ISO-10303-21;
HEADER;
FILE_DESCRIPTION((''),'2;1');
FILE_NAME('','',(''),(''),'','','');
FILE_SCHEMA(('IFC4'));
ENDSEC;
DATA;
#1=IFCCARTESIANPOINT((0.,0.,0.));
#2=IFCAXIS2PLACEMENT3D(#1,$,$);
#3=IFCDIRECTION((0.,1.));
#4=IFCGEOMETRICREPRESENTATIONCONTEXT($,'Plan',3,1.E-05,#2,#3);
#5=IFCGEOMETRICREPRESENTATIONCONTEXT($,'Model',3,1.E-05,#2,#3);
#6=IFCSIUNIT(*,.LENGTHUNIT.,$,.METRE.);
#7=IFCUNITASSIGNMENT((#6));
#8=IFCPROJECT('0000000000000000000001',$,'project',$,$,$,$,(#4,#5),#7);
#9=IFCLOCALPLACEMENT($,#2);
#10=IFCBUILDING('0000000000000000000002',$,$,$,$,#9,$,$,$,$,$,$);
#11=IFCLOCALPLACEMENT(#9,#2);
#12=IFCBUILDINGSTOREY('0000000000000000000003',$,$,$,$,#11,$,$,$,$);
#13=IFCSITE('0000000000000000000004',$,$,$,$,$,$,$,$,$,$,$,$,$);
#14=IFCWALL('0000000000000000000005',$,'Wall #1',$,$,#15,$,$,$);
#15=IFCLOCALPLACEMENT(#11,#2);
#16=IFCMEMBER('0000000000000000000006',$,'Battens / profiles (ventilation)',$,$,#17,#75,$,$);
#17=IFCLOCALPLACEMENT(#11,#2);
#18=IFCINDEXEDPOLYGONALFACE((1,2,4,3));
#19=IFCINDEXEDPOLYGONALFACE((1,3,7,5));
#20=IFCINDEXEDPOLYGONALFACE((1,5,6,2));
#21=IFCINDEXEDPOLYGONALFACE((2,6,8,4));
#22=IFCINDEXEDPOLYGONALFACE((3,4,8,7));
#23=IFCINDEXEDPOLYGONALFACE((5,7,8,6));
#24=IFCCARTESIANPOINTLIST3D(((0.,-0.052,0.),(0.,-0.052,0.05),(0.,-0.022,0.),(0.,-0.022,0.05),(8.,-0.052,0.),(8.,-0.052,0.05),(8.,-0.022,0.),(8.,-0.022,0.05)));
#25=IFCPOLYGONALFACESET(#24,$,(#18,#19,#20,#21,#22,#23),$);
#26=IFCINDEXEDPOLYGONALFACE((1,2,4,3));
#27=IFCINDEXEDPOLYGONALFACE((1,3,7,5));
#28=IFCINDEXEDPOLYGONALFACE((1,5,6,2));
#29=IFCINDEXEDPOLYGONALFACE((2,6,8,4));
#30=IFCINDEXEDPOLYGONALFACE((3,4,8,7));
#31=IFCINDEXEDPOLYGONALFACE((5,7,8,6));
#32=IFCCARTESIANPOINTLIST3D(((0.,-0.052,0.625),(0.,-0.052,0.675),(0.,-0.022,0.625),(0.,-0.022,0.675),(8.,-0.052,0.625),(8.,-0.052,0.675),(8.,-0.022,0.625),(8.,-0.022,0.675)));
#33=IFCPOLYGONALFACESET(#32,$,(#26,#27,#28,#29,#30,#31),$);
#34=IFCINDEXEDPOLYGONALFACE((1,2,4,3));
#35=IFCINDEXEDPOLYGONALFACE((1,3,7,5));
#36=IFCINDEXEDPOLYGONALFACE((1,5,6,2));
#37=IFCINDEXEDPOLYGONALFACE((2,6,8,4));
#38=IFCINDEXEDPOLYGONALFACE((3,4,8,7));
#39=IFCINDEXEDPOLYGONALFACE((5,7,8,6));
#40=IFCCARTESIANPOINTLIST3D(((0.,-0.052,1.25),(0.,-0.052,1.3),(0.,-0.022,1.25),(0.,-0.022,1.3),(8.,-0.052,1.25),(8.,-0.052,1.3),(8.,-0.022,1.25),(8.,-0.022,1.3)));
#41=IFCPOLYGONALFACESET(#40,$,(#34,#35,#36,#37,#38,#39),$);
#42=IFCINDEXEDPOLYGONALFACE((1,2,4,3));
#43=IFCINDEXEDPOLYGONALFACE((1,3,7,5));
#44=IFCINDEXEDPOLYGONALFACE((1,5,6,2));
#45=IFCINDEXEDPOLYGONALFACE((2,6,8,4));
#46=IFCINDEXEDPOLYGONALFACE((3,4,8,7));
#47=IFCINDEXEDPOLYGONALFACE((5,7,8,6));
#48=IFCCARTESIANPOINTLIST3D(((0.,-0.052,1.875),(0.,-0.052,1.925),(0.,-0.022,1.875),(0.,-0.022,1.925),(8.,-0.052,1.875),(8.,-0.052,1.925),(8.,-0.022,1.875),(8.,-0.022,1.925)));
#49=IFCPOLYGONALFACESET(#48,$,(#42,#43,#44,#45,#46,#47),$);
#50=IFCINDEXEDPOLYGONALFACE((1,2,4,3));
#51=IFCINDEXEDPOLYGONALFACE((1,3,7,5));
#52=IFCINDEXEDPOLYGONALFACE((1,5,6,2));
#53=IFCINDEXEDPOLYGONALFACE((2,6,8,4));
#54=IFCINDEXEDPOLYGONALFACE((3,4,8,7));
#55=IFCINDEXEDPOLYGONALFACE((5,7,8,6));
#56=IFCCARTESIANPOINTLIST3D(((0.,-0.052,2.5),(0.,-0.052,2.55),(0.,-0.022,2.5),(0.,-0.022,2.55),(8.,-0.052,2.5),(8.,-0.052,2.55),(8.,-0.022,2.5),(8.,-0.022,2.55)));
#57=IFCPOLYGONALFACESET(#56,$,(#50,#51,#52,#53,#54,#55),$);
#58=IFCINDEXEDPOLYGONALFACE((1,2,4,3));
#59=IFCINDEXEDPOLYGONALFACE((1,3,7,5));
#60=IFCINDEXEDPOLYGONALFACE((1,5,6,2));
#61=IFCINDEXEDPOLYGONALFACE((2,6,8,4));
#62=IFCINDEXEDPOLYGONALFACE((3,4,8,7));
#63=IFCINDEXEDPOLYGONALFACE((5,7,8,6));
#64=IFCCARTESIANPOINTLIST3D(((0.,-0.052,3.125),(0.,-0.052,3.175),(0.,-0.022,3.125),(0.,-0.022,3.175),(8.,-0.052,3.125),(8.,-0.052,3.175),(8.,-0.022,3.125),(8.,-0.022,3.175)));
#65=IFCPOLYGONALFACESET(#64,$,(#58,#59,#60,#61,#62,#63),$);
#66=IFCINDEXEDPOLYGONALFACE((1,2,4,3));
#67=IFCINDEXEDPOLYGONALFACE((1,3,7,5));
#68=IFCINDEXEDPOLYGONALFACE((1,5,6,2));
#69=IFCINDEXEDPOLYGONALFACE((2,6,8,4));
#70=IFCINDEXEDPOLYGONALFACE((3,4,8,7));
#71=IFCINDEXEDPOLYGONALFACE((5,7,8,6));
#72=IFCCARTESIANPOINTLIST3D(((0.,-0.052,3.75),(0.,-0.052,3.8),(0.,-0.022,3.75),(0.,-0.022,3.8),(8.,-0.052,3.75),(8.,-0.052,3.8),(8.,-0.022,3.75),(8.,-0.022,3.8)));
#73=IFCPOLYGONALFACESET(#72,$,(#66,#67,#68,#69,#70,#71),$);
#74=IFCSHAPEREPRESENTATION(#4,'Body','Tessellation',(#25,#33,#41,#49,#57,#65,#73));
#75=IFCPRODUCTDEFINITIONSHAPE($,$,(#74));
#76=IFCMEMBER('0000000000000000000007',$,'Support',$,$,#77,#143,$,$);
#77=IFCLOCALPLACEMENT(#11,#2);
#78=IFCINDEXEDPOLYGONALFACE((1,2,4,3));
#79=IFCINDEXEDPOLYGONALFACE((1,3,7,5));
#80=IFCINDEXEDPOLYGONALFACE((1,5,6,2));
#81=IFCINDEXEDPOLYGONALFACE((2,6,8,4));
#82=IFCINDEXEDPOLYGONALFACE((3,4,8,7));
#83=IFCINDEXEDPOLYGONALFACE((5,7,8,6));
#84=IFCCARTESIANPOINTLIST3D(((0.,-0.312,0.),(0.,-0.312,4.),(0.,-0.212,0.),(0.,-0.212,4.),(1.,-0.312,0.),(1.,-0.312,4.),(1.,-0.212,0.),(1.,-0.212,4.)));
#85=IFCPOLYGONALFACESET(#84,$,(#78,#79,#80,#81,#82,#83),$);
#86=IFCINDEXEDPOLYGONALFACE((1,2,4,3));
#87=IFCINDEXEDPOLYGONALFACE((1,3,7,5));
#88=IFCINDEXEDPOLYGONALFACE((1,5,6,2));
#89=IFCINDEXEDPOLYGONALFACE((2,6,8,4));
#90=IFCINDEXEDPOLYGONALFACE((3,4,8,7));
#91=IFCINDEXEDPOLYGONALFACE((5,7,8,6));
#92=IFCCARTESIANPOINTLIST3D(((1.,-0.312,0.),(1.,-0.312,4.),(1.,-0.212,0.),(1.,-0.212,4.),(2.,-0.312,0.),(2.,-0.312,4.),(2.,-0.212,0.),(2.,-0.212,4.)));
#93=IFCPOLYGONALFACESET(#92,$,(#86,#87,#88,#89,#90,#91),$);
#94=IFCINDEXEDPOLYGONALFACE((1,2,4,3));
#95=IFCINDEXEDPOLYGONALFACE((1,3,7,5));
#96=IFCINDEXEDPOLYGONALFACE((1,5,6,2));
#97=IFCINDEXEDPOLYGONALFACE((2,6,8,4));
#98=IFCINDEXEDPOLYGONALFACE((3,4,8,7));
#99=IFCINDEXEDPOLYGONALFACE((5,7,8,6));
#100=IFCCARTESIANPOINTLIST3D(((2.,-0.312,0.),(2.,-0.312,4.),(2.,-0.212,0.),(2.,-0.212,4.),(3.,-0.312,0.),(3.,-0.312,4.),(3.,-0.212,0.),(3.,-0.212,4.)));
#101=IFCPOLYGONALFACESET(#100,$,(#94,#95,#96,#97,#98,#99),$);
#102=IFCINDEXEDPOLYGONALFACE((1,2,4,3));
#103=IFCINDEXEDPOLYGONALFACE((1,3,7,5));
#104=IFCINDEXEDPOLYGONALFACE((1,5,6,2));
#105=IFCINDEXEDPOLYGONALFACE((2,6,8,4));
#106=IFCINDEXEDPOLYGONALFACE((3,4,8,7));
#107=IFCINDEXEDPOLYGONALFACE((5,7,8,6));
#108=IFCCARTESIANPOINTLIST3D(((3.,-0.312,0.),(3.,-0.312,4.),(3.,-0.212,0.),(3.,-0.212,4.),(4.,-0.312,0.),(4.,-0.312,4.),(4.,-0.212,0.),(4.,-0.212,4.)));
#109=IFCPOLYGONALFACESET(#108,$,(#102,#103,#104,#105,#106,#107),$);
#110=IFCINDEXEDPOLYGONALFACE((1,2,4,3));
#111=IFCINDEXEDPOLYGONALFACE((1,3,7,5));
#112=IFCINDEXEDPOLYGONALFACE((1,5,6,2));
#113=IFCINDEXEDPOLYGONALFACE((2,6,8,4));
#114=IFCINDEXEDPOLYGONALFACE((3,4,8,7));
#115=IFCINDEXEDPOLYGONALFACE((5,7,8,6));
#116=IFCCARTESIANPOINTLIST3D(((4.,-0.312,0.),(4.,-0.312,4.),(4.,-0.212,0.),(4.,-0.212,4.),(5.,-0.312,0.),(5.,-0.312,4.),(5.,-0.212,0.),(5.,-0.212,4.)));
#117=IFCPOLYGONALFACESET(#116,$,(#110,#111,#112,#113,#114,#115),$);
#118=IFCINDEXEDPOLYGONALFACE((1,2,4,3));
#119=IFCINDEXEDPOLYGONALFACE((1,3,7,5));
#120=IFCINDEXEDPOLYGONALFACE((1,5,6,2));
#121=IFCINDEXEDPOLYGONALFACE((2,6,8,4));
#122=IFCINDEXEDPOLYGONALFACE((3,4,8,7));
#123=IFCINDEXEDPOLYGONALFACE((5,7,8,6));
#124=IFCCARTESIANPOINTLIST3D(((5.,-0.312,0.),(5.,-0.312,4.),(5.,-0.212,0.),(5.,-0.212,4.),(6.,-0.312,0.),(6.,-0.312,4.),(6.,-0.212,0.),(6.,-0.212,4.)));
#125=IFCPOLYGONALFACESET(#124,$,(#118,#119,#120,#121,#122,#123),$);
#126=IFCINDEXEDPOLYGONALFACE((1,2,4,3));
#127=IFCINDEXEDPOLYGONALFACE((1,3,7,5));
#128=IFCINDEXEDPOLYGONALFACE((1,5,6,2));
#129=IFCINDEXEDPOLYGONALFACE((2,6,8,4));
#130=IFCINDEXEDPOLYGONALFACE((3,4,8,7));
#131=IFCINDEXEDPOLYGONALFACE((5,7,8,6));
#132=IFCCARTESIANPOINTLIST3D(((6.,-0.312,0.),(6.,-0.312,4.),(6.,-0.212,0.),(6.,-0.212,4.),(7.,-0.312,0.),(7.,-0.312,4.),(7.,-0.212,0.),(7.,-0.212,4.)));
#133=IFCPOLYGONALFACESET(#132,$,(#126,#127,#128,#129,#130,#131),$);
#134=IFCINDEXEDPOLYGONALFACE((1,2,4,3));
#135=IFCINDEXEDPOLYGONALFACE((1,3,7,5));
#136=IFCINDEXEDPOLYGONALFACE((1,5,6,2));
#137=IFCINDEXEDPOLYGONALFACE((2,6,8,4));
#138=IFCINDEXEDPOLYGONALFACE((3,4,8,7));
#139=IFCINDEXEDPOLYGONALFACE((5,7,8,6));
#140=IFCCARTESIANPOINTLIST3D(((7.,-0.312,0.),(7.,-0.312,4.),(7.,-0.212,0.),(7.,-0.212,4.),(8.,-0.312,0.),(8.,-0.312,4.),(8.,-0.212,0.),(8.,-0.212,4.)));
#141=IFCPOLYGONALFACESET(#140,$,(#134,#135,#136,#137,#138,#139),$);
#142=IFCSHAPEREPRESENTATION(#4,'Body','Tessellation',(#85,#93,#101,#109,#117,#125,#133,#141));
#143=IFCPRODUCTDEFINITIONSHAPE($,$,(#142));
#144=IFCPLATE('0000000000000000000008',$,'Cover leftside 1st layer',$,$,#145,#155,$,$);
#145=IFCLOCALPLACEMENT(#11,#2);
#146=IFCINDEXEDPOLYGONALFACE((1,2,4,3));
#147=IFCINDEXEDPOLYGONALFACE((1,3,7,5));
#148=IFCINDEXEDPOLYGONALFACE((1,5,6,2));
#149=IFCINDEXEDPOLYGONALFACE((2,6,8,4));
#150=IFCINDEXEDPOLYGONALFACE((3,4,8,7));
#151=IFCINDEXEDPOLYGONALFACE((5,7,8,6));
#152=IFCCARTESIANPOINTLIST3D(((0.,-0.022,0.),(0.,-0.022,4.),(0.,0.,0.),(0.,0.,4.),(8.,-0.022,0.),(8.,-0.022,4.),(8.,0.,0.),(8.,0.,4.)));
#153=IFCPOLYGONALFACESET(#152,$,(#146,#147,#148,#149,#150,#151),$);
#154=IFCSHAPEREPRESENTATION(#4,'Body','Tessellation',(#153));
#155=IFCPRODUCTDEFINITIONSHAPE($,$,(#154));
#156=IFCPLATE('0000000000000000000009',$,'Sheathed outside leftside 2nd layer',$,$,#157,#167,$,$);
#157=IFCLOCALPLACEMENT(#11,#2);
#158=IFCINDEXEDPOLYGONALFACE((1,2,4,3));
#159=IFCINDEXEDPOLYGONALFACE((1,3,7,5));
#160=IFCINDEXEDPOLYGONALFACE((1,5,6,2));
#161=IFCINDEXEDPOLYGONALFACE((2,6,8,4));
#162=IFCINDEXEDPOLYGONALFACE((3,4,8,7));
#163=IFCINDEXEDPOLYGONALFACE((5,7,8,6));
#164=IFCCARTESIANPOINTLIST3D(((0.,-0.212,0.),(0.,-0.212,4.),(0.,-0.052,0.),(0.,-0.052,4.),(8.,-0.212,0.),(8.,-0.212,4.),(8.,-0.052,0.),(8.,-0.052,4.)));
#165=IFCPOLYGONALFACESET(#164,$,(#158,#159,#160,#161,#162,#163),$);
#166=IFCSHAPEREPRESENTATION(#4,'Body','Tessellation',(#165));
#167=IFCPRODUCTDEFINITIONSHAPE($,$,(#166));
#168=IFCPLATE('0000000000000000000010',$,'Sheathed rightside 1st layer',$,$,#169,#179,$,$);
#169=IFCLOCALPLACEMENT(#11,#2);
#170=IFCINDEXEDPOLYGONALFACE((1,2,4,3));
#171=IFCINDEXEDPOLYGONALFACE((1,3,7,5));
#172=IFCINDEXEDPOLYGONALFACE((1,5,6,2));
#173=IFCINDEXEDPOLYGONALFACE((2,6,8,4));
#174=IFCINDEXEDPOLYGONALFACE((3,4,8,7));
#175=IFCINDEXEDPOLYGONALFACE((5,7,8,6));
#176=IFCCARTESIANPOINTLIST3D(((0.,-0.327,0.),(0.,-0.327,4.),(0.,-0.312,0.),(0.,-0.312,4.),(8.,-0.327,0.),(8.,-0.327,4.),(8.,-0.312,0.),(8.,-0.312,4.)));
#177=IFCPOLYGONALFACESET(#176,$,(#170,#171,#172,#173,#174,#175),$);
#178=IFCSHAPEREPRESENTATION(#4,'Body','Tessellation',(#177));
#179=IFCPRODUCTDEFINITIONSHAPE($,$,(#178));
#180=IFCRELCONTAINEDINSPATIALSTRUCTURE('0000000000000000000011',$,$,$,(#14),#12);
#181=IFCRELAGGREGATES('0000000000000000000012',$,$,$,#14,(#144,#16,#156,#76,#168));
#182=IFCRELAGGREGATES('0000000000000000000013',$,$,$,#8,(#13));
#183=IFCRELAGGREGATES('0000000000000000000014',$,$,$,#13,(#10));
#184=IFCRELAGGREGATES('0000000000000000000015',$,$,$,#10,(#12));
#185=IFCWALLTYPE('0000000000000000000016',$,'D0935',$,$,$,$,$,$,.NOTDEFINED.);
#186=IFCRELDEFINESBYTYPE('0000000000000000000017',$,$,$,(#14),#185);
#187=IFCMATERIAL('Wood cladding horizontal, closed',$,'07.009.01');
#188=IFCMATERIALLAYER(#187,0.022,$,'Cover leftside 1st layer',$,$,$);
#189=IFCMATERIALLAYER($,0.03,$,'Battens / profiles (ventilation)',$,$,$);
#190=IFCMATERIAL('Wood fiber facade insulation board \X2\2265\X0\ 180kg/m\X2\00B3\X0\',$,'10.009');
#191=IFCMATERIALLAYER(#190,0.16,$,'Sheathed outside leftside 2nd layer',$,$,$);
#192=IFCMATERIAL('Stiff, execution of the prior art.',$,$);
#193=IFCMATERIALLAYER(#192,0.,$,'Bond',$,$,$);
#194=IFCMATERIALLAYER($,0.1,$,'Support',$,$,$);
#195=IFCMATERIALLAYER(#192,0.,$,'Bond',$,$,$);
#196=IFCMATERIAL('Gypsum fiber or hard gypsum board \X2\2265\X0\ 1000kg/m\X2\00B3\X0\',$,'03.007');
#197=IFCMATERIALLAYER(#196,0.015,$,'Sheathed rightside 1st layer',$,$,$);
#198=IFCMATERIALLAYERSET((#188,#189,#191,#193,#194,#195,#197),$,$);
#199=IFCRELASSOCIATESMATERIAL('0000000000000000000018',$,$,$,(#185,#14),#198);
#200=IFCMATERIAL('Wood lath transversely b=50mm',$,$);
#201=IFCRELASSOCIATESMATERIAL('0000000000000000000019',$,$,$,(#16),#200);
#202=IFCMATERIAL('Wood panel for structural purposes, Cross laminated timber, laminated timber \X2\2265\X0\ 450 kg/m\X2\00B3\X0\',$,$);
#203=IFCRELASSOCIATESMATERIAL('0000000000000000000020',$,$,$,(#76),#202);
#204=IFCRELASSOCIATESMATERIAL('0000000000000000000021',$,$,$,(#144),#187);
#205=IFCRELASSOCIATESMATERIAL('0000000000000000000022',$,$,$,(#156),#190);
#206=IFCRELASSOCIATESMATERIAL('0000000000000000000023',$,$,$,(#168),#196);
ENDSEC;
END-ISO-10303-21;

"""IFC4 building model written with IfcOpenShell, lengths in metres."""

from ifc_helpers import new_model, si_unit, direction, frame, frame_2d, origin, origin_with_axes, place, context, project, spatial, rectangle, extrude, material, layer, layer_set, type_object, element, aggregate, save


model = new_model("IFC4")

# Units and contexts
plan_context = context("Plan", 3, precision=1e-05, world=origin(), true_north=direction((0.0, 1.0)))
model_context = context("Model", 3, precision=1e-05, world=origin(), true_north=direction((0.0, 1.0)))
ifc_project = project(units=[si_unit("LENGTHUNIT", "METRE")], contexts=[plan_context, model_context])

# Site, building, storey
site = spatial("IfcSite", under=ifc_project)
building_placement = place(None, origin())
building = spatial("IfcBuilding", under=site, at=building_placement)
storey_placement = place(building_placement, origin())
storey = spatial("IfcBuildingStorey", under=building, at=storey_placement)

# Wall, members, plates
ifc_material_1 = material(Name="Wood cladding horizontal, closed", Category="07.009.01")
ifc_layer_1 = layer(ifc_material_1, 0.022, Name="Cover leftside 1st layer")
ifc_layer_2 = layer(None, 0.03, Name="Battens / profiles (ventilation)")
ifc_material_2 = material(Name="Wood fiber facade insulation board ≥ 180kg/m³", Category="10.009")
ifc_layer_3 = layer(ifc_material_2, 0.16, Name="Sheathed outside leftside 2nd layer")
ifc_material_3 = material(Name="Stiff, execution of the prior art.")
ifc_layer_4 = layer(ifc_material_3, 0.0, Name="Bond")
ifc_layer_5 = layer(None, 0.1, Name="Support")
ifc_layer_6 = layer(ifc_material_3, 0.0, Name="Bond")
ifc_material_4 = material(Name="Gypsum fiber or hard gypsum board ≥ 1000kg/m³", Category="03.007")
ifc_layer_7 = layer(ifc_material_4, 0.015, Name="Sheathed rightside 1st layer")
ifc_layer_set = layer_set([ifc_layer_1, ifc_layer_2, ifc_layer_3, ifc_layer_4, ifc_layer_5, ifc_layer_6, ifc_layer_7])
wall_type = type_object("IfcWallType", Name="D0935", PredefinedType="NOTDEFINED", material=ifc_layer_set)
wall_placement = place(None, frame((0.0, 0.0, 0.0), z_axis=(0.0, -1.0, 0.0), x_axis=(1.0, 0.0, 0.0)))
wall = element("IfcWall", 1, at=wall_placement, inside=storey, type_object=wall_type, material=ifc_layer_set, Name="Wall #1")
ifc_material_5 = material(Name="Wood lath transversely b=50mm")
member_1_placement = place(wall_placement, origin())
member_1 = element("IfcMember", 2, at=member_1_placement, material=ifc_material_5, Name="Battens / profiles (ventilation)", context=plan_context, shape_type="SweptSolid", body=[
    extrude(rectangle(XDim=0.05, YDim=0.03, at=frame_2d((0.025, 0.015), x_axis=(1.0, 0.0))), frame((0.0, 0.0, 0.022), z_axis=(1.0, 0.0, 0.0), x_axis=(0.0, 1.0, 0.0)), (0.0, 0.0, 1.0), 8.0),
    extrude(rectangle(XDim=0.05, YDim=0.03, at=frame_2d((0.025, 0.015), x_axis=(1.0, 0.0))), frame((0.0, 0.625, 0.022), z_axis=(1.0, 0.0, 0.0), x_axis=(0.0, 1.0, 0.0)), (0.0, 0.0, 1.0), 8.0),
    extrude(rectangle(XDim=0.05, YDim=0.03, at=frame_2d((0.025, 0.015), x_axis=(1.0, 0.0))), frame((0.0, 1.25, 0.022), z_axis=(1.0, 0.0, 0.0), x_axis=(0.0, 1.0, 0.0)), (0.0, 0.0, 1.0), 8.0),
    extrude(rectangle(XDim=0.05, YDim=0.03, at=frame_2d((0.025, 0.015), x_axis=(1.0, 0.0))), frame((0.0, 1.875, 0.022), z_axis=(1.0, 0.0, 0.0), x_axis=(0.0, 1.0, 0.0)), (0.0, 0.0, 1.0), 8.0),
    extrude(rectangle(XDim=0.05, YDim=0.03, at=frame_2d((0.025, 0.015), x_axis=(1.0, 0.0))), frame((0.0, 2.5, 0.022), z_axis=(1.0, 0.0, 0.0), x_axis=(0.0, 1.0, 0.0)), (0.0, 0.0, 1.0), 8.0),
    extrude(rectangle(XDim=0.05, YDim=0.03, at=frame_2d((0.025, 0.015), x_axis=(1.0, 0.0))), frame((0.0, 3.125, 0.022), z_axis=(1.0, 0.0, 0.0), x_axis=(0.0, 1.0, 0.0)), (0.0, 0.0, 1.0), 8.0),
    extrude(rectangle(XDim=0.05, YDim=0.03, at=frame_2d((0.025, 0.015), x_axis=(1.0, 0.0))), frame((0.0, 3.75, 0.022), z_axis=(1.0, 0.0, 0.0), x_axis=(0.0, 1.0, 0.0)), (0.0, 0.0, 1.0), 8.0),
])
ifc_material_6 = material(Name="Wood panel for structural purposes, Cross laminated timber, laminated timber ≥ 450 kg/m³")
member_2_placement = place(wall_placement, origin())
member_2 = element("IfcMember", 3, at=member_2_placement, material=ifc_material_6, Name="Support", context=plan_context, shape_type="SweptSolid", body=[
    extrude(rectangle(XDim=1.0, YDim=0.1, at=frame_2d((0.5, 0.05), x_axis=(1.0, 0.0))), frame((0.0, 4.0, 0.212), z_axis=(0.0, -1.0, 0.0), x_axis=(1.0, 0.0, 0.0)), (0.0, 0.0, 1.0), 4.0),
    extrude(rectangle(XDim=1.0, YDim=0.1, at=frame_2d((0.5, 0.05), x_axis=(1.0, 0.0))), frame((1.0, 4.0, 0.212), z_axis=(0.0, -1.0, 0.0), x_axis=(1.0, 0.0, 0.0)), (0.0, 0.0, 1.0), 4.0),
    extrude(rectangle(XDim=1.0, YDim=0.1, at=frame_2d((0.5, 0.05), x_axis=(1.0, 0.0))), frame((2.0, 4.0, 0.212), z_axis=(0.0, -1.0, 0.0), x_axis=(1.0, 0.0, 0.0)), (0.0, 0.0, 1.0), 4.0),
    extrude(rectangle(XDim=1.0, YDim=0.1, at=frame_2d((0.5, 0.05), x_axis=(1.0, 0.0))), frame((3.0, 4.0, 0.212), z_axis=(0.0, -1.0, 0.0), x_axis=(1.0, 0.0, 0.0)), (0.0, 0.0, 1.0), 4.0),
    extrude(rectangle(XDim=1.0, YDim=0.1, at=frame_2d((0.5, 0.05), x_axis=(1.0, 0.0))), frame((4.0, 4.0, 0.212), z_axis=(0.0, -1.0, 0.0), x_axis=(1.0, 0.0, 0.0)), (0.0, 0.0, 1.0), 4.0),
    extrude(rectangle(XDim=1.0, YDim=0.1, at=frame_2d((0.5, 0.05), x_axis=(1.0, 0.0))), frame((5.0, 4.0, 0.212), z_axis=(0.0, -1.0, 0.0), x_axis=(1.0, 0.0, 0.0)), (0.0, 0.0, 1.0), 4.0),
    extrude(rectangle(XDim=1.0, YDim=0.1, at=frame_2d((0.5, 0.05), x_axis=(1.0, 0.0))), frame((6.0, 4.0, 0.212), z_axis=(0.0, -1.0, 0.0), x_axis=(1.0, 0.0, 0.0)), (0.0, 0.0, 1.0), 4.0),
    extrude(rectangle(XDim=1.0, YDim=0.1, at=frame_2d((0.5, 0.05), x_axis=(1.0, 0.0))), frame((7.0, 4.0, 0.212), z_axis=(0.0, -1.0, 0.0), x_axis=(1.0, 0.0, 0.0)), (0.0, 0.0, 1.0), 4.0),
])
plate_1_placement = place(wall_placement, origin())
plate_1 = element("IfcPlate", 4, at=plate_1_placement, material=ifc_material_1, Name="Cover leftside 1st layer", context=plan_context, shape_type="SweptSolid", body=[
    extrude(rectangle(XDim=8.0, YDim=4.0, at=frame_2d((4.0, 2.0), x_axis=(1.0, 0.0))), origin_with_axes(), (0.0, 0.0, 1.0), 0.022),
])
plate_2_placement = place(wall_placement, origin())
plate_2 = element("IfcPlate", 5, at=plate_2_placement, material=ifc_material_2, Name="Sheathed outside leftside 2nd layer", context=plan_context, shape_type="SweptSolid", body=[
    extrude(rectangle(XDim=8.0, YDim=4.0, at=frame_2d((4.0, 2.0), x_axis=(1.0, 0.0))), frame((0.0, 0.0, 0.052), z_axis=(0.0, 0.0, 1.0), x_axis=(1.0, 0.0, 0.0)), (0.0, 0.0, 1.0), 0.16),
])
plate_3_placement = place(wall_placement, origin())
plate_3 = element("IfcPlate", 6, at=plate_3_placement, material=ifc_material_4, Name="Sheathed rightside 1st layer", context=plan_context, shape_type="SweptSolid", body=[
    extrude(rectangle(XDim=8.0, YDim=4.0, at=frame_2d((4.0, 2.0), x_axis=(1.0, 0.0))), frame((0.0, 0.0, 0.312), z_axis=(0.0, 0.0, 1.0), x_axis=(1.0, 0.0, 0.0)), (0.0, 0.0, 1.0), 0.015),
])
aggregate(wall, [plate_1, member_1, plate_2, member_2, plate_3])

save(model, "model.ifc")
